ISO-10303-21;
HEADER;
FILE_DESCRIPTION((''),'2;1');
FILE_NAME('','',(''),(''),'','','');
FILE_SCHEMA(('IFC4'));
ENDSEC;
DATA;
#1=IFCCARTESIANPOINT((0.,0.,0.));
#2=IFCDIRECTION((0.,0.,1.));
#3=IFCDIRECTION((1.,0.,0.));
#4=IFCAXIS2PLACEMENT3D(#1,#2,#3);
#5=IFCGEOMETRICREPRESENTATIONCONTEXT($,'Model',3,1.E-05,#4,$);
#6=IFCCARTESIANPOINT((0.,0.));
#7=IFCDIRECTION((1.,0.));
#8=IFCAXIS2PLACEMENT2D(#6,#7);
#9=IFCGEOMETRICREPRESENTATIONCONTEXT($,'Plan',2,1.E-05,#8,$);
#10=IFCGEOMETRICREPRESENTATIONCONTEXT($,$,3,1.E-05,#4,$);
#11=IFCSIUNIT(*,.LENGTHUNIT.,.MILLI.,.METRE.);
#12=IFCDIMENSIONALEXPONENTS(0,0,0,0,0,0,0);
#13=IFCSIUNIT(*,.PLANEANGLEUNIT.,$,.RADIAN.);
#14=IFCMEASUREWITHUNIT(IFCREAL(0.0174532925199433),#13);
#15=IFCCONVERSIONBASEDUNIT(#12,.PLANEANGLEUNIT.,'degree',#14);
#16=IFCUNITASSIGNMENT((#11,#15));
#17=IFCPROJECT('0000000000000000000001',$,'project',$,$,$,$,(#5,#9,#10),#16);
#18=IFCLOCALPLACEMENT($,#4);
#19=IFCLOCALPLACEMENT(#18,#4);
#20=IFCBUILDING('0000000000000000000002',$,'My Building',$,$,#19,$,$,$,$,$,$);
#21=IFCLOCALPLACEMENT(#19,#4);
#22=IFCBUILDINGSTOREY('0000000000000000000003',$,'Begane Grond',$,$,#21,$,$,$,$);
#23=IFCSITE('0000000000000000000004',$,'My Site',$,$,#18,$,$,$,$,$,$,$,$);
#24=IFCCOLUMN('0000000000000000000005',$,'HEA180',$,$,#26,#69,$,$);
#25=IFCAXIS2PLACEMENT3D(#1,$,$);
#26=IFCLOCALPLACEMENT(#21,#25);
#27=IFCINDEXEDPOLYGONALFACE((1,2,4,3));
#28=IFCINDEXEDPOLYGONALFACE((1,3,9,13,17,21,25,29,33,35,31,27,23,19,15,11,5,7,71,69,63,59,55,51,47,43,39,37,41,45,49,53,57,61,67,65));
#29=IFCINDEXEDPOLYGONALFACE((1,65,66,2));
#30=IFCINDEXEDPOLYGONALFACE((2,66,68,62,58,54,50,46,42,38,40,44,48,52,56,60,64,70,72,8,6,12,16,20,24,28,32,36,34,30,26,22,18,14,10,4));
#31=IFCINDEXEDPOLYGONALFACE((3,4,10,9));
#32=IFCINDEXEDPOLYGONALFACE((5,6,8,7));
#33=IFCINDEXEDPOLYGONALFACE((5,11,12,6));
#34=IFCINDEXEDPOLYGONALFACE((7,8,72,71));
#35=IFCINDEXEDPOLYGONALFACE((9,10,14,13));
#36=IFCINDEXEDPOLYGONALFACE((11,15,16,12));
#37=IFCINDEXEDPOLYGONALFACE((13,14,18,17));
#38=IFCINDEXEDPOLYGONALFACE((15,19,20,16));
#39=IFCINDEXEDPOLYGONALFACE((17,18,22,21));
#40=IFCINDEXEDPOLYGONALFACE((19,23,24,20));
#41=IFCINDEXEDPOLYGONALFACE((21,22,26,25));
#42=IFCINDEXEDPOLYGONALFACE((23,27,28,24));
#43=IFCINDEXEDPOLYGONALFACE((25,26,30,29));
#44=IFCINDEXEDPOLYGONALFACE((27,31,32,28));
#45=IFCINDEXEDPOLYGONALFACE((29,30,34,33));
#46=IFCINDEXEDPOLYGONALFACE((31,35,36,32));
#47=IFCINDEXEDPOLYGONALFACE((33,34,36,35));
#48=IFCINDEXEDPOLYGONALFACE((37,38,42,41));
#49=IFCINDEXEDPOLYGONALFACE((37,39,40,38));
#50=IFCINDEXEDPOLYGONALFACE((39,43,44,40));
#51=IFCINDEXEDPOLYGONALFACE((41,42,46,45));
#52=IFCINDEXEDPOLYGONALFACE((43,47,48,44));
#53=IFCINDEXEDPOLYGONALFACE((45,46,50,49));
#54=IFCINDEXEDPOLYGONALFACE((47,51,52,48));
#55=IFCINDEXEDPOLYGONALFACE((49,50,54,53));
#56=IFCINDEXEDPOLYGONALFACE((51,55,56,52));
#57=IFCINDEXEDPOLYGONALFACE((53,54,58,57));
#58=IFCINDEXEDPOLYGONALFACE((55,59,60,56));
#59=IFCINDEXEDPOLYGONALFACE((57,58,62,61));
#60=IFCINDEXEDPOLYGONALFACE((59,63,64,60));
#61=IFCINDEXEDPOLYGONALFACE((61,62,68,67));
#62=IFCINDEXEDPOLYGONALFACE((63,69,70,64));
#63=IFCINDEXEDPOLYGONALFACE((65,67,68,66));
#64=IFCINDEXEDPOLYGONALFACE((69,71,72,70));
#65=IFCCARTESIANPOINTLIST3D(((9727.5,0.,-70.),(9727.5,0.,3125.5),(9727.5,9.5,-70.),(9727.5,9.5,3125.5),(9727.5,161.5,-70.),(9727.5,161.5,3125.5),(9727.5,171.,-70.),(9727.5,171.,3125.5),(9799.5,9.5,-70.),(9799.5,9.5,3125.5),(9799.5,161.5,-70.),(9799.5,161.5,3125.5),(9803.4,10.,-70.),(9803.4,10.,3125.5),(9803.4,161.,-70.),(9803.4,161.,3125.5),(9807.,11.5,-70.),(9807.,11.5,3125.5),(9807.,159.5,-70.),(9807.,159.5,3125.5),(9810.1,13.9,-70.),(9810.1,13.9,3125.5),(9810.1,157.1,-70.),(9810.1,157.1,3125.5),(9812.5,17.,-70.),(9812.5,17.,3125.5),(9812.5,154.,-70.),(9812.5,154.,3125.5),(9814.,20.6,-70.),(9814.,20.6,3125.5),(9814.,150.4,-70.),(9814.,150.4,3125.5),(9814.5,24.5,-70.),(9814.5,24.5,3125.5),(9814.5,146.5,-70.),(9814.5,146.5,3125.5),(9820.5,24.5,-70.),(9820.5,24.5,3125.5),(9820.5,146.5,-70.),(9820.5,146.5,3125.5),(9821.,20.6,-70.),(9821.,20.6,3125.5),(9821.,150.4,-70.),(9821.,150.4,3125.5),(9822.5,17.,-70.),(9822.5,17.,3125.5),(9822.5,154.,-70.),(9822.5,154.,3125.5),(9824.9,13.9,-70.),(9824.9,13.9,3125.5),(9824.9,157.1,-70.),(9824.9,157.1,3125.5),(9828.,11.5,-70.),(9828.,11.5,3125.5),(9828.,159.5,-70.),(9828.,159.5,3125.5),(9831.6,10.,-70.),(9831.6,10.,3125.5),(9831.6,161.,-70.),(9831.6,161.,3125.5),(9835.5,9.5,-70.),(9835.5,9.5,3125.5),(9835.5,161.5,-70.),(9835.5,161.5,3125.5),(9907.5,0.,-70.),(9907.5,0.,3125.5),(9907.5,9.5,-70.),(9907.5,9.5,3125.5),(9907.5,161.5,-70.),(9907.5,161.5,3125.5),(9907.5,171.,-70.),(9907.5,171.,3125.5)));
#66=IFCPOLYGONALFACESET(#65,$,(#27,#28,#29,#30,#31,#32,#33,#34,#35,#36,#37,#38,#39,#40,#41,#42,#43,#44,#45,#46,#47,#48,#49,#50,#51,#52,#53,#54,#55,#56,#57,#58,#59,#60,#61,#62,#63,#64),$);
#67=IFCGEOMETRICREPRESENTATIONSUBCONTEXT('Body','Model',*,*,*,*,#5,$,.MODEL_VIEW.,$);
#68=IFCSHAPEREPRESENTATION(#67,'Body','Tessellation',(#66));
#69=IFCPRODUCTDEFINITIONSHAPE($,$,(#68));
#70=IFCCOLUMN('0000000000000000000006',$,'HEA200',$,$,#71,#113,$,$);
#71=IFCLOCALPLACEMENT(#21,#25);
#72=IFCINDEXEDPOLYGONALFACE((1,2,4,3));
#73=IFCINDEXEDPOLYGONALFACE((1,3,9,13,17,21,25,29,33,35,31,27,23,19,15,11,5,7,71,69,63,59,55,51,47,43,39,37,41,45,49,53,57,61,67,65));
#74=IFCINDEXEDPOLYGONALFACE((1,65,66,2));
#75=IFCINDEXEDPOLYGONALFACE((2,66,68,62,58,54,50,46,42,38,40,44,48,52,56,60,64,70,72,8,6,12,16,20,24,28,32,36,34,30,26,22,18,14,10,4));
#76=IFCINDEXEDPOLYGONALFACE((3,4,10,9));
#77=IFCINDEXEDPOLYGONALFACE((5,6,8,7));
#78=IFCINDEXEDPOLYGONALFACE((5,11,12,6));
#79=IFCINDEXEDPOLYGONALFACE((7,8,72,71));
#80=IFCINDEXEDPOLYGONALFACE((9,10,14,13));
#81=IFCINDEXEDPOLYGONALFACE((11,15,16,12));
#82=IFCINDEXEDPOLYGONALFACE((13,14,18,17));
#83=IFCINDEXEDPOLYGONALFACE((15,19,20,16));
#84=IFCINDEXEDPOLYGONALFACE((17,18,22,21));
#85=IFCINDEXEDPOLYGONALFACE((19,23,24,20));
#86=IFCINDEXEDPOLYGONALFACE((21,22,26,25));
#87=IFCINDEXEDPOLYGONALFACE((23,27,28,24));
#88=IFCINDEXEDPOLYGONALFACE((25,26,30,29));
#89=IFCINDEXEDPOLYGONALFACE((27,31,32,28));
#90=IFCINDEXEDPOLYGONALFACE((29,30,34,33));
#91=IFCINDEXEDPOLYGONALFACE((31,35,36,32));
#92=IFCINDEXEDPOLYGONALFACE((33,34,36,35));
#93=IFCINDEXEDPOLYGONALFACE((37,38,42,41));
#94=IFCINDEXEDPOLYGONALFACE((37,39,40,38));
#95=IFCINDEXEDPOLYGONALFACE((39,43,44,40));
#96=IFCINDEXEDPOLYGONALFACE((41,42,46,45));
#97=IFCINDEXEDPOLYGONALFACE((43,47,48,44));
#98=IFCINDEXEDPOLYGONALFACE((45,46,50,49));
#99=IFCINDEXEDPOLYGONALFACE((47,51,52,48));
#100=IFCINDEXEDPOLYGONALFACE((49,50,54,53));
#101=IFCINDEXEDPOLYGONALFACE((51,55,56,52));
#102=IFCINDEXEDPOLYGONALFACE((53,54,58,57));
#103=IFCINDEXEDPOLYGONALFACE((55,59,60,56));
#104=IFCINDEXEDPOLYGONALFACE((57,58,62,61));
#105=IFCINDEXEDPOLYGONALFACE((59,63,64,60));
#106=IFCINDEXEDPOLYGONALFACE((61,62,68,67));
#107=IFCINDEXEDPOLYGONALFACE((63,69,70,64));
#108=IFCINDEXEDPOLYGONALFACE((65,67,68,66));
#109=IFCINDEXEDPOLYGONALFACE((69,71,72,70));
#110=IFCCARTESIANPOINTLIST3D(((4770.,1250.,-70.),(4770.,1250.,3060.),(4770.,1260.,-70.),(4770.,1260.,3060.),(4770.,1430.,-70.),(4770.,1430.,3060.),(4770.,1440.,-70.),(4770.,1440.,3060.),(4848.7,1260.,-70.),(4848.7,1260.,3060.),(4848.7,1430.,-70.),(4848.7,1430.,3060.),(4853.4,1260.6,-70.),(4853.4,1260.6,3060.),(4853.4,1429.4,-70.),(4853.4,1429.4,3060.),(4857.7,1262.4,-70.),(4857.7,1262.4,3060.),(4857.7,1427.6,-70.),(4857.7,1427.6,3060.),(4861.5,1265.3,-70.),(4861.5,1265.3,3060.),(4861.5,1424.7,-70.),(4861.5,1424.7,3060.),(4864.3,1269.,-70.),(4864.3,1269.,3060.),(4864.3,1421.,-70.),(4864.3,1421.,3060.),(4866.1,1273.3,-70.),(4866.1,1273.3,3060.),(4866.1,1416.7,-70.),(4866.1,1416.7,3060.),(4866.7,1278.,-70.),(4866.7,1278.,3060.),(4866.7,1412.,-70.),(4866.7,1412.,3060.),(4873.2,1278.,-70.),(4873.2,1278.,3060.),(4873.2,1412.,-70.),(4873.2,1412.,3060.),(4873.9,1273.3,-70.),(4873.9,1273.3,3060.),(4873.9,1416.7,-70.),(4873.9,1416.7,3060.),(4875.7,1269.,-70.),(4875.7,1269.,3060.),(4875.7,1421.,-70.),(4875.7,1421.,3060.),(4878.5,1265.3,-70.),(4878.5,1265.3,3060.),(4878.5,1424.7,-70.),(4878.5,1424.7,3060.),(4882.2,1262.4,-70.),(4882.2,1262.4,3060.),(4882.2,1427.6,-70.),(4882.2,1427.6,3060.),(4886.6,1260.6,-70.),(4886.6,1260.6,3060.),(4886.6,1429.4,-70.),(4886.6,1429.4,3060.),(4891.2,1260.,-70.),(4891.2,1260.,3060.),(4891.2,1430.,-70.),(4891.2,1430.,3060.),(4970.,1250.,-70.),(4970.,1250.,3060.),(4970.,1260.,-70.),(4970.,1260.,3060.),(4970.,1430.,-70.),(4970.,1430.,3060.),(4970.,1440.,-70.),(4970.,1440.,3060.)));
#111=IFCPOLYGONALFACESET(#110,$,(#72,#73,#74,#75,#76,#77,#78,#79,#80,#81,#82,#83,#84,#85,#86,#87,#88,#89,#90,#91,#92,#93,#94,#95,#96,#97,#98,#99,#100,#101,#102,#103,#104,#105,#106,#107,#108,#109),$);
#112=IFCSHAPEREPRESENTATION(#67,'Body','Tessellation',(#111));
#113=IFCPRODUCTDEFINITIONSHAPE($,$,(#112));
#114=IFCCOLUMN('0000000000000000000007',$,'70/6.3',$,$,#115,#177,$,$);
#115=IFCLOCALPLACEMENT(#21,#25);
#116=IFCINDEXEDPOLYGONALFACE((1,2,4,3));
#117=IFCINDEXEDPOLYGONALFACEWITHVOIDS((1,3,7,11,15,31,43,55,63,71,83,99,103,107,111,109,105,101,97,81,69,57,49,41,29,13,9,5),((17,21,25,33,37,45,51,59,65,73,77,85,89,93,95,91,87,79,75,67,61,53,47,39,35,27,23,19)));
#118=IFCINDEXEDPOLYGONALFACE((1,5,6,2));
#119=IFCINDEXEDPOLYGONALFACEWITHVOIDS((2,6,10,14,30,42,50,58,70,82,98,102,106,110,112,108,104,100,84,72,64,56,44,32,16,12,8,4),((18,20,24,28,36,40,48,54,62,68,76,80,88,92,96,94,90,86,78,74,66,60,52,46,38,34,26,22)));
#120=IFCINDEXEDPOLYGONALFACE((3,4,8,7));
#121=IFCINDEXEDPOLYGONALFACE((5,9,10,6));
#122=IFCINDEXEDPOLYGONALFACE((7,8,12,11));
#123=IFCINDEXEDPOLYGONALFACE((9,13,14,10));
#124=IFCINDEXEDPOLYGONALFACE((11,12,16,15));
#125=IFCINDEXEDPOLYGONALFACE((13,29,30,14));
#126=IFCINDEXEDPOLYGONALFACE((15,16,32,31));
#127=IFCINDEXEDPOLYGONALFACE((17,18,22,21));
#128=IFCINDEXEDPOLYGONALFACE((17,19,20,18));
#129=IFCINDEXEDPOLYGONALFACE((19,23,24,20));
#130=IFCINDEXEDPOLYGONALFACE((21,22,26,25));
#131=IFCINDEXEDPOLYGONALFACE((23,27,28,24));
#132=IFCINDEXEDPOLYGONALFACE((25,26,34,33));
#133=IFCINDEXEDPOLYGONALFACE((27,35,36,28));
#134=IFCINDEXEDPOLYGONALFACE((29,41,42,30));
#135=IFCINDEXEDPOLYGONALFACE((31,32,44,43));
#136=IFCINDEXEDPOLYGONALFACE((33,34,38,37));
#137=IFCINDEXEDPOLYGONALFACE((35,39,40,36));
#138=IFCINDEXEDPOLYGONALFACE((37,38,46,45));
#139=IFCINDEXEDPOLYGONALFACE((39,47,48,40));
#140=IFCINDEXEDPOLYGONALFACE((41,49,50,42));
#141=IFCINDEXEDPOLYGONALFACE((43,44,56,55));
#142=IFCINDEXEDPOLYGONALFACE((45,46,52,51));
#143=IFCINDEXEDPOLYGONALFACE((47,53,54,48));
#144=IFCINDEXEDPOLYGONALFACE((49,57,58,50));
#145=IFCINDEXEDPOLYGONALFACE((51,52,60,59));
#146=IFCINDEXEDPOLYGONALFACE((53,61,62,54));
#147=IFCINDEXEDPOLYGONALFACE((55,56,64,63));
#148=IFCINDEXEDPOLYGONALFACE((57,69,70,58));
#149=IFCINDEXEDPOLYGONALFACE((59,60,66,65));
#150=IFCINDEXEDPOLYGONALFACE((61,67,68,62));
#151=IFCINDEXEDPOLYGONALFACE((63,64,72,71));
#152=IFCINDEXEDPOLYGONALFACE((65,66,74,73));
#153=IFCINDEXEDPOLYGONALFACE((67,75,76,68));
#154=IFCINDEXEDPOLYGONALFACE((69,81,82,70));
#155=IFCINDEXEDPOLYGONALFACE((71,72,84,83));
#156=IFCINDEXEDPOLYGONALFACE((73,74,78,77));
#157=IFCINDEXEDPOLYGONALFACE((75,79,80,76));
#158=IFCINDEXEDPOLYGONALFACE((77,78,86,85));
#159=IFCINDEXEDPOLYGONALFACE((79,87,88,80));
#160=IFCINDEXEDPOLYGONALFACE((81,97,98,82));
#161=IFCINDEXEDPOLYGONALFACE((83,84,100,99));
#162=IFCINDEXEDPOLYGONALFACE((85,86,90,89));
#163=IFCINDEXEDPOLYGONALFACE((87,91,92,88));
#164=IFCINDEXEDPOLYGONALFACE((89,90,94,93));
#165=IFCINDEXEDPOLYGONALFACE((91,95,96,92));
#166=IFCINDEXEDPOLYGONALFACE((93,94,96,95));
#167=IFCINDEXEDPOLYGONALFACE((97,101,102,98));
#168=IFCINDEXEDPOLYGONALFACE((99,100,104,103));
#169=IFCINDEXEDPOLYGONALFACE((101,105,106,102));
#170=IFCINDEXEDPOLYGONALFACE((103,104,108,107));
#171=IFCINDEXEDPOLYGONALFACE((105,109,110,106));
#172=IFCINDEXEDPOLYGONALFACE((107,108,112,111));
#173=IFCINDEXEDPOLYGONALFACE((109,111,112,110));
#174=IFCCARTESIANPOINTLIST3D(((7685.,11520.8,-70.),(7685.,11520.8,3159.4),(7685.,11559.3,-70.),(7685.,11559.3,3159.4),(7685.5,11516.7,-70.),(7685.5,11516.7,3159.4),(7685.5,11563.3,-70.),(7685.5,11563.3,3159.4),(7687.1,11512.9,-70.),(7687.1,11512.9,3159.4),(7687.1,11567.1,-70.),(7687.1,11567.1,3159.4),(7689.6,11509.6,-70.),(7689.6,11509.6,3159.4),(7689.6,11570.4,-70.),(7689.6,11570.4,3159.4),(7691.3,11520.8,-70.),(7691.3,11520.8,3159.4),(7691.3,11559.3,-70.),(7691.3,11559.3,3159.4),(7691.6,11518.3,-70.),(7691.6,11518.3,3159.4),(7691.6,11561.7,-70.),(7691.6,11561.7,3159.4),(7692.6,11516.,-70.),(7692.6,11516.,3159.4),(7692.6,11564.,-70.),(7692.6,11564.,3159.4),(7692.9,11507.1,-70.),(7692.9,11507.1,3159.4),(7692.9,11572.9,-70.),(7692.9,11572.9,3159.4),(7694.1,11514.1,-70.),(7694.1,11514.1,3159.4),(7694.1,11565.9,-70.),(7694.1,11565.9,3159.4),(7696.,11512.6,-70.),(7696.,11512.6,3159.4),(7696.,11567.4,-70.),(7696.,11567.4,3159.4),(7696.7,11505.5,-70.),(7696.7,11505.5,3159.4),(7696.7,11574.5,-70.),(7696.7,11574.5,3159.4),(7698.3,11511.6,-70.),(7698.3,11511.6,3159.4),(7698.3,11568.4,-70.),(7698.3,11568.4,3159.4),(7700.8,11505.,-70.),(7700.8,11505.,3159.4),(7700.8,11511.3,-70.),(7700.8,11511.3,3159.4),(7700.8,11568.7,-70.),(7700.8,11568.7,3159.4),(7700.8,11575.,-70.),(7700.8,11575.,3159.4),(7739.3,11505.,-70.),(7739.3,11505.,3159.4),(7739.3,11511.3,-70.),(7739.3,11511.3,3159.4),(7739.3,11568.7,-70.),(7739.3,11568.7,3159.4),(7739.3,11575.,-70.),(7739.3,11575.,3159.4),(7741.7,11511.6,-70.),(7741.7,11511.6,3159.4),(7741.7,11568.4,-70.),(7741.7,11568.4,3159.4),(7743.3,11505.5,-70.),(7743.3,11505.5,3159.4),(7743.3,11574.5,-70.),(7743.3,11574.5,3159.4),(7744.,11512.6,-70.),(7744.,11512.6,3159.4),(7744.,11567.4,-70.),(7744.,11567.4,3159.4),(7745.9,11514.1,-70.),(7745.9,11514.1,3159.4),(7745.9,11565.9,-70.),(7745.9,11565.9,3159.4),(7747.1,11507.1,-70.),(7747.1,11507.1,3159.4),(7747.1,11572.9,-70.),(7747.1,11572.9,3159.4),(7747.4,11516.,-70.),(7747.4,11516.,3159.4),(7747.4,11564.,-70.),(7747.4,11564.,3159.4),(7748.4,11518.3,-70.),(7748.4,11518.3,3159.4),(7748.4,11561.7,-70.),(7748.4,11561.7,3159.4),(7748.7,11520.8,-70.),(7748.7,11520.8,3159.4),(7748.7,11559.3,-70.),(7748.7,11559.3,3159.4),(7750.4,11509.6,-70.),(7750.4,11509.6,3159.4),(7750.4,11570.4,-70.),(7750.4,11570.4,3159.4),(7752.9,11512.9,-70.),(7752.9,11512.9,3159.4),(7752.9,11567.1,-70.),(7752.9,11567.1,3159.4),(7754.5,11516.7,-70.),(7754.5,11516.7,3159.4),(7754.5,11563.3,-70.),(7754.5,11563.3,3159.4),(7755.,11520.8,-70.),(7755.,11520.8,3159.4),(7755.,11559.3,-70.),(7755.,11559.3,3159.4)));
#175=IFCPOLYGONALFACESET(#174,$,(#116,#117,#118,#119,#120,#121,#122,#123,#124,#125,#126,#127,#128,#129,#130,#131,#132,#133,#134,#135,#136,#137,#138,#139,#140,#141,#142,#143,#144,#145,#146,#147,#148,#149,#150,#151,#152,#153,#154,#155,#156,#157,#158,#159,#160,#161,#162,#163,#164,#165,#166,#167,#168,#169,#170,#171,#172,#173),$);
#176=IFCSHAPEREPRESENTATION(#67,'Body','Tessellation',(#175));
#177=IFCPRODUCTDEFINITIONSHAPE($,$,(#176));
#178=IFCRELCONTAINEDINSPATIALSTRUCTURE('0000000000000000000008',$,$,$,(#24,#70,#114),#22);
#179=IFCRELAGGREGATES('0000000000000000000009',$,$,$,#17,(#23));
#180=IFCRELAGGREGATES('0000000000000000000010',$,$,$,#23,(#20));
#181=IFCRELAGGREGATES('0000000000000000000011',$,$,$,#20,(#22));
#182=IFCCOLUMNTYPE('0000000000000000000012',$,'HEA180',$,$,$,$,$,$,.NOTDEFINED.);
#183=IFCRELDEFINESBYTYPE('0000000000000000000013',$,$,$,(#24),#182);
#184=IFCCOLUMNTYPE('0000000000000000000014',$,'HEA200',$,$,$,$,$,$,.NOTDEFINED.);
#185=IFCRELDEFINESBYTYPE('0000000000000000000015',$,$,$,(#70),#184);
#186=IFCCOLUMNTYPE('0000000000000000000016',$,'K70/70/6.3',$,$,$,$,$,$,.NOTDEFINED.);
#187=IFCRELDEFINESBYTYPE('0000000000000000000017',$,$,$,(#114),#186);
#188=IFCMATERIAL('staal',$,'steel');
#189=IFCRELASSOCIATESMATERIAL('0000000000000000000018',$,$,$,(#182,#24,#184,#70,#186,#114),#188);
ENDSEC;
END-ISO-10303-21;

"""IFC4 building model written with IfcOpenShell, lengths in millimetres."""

from ifc_helpers import new_model, entity, si_unit, converted_unit, frame, origin_with_axes, origin_2d_with_axis, place, context, subcontext, project, spatial, hollow_rectangle, i_section, extrude, material, material_profile, profile_set, profile_usage, type_object, element, save


model = new_model("IFC4")

# Units and contexts
model_context = context("Model", 3, precision=1e-05, world=origin_with_axes())
plan_context = context("Plan", 2, precision=1e-05, world=origin_2d_with_axis())
context_of_model = context(None, 3, precision=1e-05, world=origin_with_axes())
body_context = subcontext(model_context, "Body", "Model", "MODEL_VIEW")
ifc_project = project(units=[si_unit("LENGTHUNIT", "METRE", prefix="MILLI"), converted_unit("PLANEANGLEUNIT", "degree", entity("IfcReal", 0.0174532925199433), si_unit("PLANEANGLEUNIT", "RADIAN"), dimensions=[0, 0, 0, 0, 0, 0, 0])], contexts=[model_context, plan_context, context_of_model])

# Site, building, storey
site_placement = place(None, origin_with_axes())
site = spatial("IfcSite", under=ifc_project, at=site_placement, Name="My Site")
building_placement = place(site_placement, origin_with_axes())
building = spatial("IfcBuilding", under=site, at=building_placement, Name="My Building")
storey_placement = place(building_placement, origin_with_axes())
storey = spatial("IfcBuildingStorey", under=building, at=storey_placement, Name="Begane Grond")

# Columns
ifc_material = material(Name="staal", Category="steel")
ifc_material_profile_1 = material_profile(ifc_material, i_section(OverallWidth=180.0, OverallDepth=171.0, WebThickness=6.0, FlangeThickness=9.5, FilletRadius=15.0))
ifc_profile_set_1 = profile_set([ifc_material_profile_1], Name="HEA180")
ifc_profile_usage_1 = profile_usage(ifc_profile_set_1)
column_type_1 = type_object("IfcColumnType", Name="HEA180", PredefinedType="NOTDEFINED", material=ifc_profile_set_1)
column_1_placement = place(storey_placement, frame((9817.5, 85.5, -70.0), z_axis=(0.0, 0.0, 1.0), x_axis=(-1.0, 0.0, 0.0)))
element("IfcColumn", 1, at=column_1_placement, inside=storey, type_object=column_type_1, material=ifc_profile_usage_1, Name="HEA180", context=body_context, shape_type="SweptSolid", body=[
    extrude(i_section(OverallWidth=180.0, OverallDepth=171.0, WebThickness=6.0, FlangeThickness=9.5, FilletRadius=15.0), origin_with_axes(), (0.0, 0.0, 1.0), 3195.5),
])
ifc_material_profile_2 = material_profile(ifc_material, i_section(OverallWidth=200.0, OverallDepth=190.0, WebThickness=6.5, FlangeThickness=10.0, FilletRadius=18.0))
ifc_profile_set_2 = profile_set([ifc_material_profile_2], Name="HEA200")
ifc_profile_usage_2 = profile_usage(ifc_profile_set_2)
column_type_2 = type_object("IfcColumnType", Name="HEA200", PredefinedType="NOTDEFINED", material=ifc_profile_set_2)
column_2_placement = place(storey_placement, frame((4870.0, 1345.0, -70.0), z_axis=(0.0, 0.0, 1.0), x_axis=(-1.0, 0.0, 0.0)))
element("IfcColumn", 2, at=column_2_placement, inside=storey, type_object=column_type_2, material=ifc_profile_usage_2, Name="HEA200", context=body_context, shape_type="SweptSolid", body=[
    extrude(i_section(OverallWidth=200.0, OverallDepth=190.0, WebThickness=6.5, FlangeThickness=10.0, FilletRadius=18.0), origin_with_axes(), (0.0, 0.0, 1.0), 3130.0),
])
ifc_material_profile_3 = material_profile(ifc_material, hollow_rectangle(XDim=70.0, YDim=70.0, WallThickness=6.3, InnerFilletRadius=9.4, OuterFilletRadius=15.8))
ifc_profile_set_3 = profile_set([ifc_material_profile_3], Name="K70/70/6.3")
ifc_profile_usage_3 = profile_usage(ifc_profile_set_3)
column_type_3 = type_object("IfcColumnType", Name="K70/70/6.3", PredefinedType="NOTDEFINED", material=ifc_profile_set_3)
column_3_placement = place(storey_placement, frame((7720.0, 11540.0, -70.0), z_axis=(0.0, 0.0, 1.0), x_axis=(1.0, 0.0, 0.0)))
element("IfcColumn", 3, at=column_3_placement, inside=storey, type_object=column_type_3, material=ifc_profile_usage_3, Name="70/6.3", context=body_context, shape_type="SweptSolid", body=[
    extrude(hollow_rectangle(XDim=70.0, YDim=70.0, WallThickness=6.3, InnerFilletRadius=9.4, OuterFilletRadius=15.8), origin_with_axes(), (0.0, 0.0, 1.0), 3229.4),
])

save(model, "model.ifc")
